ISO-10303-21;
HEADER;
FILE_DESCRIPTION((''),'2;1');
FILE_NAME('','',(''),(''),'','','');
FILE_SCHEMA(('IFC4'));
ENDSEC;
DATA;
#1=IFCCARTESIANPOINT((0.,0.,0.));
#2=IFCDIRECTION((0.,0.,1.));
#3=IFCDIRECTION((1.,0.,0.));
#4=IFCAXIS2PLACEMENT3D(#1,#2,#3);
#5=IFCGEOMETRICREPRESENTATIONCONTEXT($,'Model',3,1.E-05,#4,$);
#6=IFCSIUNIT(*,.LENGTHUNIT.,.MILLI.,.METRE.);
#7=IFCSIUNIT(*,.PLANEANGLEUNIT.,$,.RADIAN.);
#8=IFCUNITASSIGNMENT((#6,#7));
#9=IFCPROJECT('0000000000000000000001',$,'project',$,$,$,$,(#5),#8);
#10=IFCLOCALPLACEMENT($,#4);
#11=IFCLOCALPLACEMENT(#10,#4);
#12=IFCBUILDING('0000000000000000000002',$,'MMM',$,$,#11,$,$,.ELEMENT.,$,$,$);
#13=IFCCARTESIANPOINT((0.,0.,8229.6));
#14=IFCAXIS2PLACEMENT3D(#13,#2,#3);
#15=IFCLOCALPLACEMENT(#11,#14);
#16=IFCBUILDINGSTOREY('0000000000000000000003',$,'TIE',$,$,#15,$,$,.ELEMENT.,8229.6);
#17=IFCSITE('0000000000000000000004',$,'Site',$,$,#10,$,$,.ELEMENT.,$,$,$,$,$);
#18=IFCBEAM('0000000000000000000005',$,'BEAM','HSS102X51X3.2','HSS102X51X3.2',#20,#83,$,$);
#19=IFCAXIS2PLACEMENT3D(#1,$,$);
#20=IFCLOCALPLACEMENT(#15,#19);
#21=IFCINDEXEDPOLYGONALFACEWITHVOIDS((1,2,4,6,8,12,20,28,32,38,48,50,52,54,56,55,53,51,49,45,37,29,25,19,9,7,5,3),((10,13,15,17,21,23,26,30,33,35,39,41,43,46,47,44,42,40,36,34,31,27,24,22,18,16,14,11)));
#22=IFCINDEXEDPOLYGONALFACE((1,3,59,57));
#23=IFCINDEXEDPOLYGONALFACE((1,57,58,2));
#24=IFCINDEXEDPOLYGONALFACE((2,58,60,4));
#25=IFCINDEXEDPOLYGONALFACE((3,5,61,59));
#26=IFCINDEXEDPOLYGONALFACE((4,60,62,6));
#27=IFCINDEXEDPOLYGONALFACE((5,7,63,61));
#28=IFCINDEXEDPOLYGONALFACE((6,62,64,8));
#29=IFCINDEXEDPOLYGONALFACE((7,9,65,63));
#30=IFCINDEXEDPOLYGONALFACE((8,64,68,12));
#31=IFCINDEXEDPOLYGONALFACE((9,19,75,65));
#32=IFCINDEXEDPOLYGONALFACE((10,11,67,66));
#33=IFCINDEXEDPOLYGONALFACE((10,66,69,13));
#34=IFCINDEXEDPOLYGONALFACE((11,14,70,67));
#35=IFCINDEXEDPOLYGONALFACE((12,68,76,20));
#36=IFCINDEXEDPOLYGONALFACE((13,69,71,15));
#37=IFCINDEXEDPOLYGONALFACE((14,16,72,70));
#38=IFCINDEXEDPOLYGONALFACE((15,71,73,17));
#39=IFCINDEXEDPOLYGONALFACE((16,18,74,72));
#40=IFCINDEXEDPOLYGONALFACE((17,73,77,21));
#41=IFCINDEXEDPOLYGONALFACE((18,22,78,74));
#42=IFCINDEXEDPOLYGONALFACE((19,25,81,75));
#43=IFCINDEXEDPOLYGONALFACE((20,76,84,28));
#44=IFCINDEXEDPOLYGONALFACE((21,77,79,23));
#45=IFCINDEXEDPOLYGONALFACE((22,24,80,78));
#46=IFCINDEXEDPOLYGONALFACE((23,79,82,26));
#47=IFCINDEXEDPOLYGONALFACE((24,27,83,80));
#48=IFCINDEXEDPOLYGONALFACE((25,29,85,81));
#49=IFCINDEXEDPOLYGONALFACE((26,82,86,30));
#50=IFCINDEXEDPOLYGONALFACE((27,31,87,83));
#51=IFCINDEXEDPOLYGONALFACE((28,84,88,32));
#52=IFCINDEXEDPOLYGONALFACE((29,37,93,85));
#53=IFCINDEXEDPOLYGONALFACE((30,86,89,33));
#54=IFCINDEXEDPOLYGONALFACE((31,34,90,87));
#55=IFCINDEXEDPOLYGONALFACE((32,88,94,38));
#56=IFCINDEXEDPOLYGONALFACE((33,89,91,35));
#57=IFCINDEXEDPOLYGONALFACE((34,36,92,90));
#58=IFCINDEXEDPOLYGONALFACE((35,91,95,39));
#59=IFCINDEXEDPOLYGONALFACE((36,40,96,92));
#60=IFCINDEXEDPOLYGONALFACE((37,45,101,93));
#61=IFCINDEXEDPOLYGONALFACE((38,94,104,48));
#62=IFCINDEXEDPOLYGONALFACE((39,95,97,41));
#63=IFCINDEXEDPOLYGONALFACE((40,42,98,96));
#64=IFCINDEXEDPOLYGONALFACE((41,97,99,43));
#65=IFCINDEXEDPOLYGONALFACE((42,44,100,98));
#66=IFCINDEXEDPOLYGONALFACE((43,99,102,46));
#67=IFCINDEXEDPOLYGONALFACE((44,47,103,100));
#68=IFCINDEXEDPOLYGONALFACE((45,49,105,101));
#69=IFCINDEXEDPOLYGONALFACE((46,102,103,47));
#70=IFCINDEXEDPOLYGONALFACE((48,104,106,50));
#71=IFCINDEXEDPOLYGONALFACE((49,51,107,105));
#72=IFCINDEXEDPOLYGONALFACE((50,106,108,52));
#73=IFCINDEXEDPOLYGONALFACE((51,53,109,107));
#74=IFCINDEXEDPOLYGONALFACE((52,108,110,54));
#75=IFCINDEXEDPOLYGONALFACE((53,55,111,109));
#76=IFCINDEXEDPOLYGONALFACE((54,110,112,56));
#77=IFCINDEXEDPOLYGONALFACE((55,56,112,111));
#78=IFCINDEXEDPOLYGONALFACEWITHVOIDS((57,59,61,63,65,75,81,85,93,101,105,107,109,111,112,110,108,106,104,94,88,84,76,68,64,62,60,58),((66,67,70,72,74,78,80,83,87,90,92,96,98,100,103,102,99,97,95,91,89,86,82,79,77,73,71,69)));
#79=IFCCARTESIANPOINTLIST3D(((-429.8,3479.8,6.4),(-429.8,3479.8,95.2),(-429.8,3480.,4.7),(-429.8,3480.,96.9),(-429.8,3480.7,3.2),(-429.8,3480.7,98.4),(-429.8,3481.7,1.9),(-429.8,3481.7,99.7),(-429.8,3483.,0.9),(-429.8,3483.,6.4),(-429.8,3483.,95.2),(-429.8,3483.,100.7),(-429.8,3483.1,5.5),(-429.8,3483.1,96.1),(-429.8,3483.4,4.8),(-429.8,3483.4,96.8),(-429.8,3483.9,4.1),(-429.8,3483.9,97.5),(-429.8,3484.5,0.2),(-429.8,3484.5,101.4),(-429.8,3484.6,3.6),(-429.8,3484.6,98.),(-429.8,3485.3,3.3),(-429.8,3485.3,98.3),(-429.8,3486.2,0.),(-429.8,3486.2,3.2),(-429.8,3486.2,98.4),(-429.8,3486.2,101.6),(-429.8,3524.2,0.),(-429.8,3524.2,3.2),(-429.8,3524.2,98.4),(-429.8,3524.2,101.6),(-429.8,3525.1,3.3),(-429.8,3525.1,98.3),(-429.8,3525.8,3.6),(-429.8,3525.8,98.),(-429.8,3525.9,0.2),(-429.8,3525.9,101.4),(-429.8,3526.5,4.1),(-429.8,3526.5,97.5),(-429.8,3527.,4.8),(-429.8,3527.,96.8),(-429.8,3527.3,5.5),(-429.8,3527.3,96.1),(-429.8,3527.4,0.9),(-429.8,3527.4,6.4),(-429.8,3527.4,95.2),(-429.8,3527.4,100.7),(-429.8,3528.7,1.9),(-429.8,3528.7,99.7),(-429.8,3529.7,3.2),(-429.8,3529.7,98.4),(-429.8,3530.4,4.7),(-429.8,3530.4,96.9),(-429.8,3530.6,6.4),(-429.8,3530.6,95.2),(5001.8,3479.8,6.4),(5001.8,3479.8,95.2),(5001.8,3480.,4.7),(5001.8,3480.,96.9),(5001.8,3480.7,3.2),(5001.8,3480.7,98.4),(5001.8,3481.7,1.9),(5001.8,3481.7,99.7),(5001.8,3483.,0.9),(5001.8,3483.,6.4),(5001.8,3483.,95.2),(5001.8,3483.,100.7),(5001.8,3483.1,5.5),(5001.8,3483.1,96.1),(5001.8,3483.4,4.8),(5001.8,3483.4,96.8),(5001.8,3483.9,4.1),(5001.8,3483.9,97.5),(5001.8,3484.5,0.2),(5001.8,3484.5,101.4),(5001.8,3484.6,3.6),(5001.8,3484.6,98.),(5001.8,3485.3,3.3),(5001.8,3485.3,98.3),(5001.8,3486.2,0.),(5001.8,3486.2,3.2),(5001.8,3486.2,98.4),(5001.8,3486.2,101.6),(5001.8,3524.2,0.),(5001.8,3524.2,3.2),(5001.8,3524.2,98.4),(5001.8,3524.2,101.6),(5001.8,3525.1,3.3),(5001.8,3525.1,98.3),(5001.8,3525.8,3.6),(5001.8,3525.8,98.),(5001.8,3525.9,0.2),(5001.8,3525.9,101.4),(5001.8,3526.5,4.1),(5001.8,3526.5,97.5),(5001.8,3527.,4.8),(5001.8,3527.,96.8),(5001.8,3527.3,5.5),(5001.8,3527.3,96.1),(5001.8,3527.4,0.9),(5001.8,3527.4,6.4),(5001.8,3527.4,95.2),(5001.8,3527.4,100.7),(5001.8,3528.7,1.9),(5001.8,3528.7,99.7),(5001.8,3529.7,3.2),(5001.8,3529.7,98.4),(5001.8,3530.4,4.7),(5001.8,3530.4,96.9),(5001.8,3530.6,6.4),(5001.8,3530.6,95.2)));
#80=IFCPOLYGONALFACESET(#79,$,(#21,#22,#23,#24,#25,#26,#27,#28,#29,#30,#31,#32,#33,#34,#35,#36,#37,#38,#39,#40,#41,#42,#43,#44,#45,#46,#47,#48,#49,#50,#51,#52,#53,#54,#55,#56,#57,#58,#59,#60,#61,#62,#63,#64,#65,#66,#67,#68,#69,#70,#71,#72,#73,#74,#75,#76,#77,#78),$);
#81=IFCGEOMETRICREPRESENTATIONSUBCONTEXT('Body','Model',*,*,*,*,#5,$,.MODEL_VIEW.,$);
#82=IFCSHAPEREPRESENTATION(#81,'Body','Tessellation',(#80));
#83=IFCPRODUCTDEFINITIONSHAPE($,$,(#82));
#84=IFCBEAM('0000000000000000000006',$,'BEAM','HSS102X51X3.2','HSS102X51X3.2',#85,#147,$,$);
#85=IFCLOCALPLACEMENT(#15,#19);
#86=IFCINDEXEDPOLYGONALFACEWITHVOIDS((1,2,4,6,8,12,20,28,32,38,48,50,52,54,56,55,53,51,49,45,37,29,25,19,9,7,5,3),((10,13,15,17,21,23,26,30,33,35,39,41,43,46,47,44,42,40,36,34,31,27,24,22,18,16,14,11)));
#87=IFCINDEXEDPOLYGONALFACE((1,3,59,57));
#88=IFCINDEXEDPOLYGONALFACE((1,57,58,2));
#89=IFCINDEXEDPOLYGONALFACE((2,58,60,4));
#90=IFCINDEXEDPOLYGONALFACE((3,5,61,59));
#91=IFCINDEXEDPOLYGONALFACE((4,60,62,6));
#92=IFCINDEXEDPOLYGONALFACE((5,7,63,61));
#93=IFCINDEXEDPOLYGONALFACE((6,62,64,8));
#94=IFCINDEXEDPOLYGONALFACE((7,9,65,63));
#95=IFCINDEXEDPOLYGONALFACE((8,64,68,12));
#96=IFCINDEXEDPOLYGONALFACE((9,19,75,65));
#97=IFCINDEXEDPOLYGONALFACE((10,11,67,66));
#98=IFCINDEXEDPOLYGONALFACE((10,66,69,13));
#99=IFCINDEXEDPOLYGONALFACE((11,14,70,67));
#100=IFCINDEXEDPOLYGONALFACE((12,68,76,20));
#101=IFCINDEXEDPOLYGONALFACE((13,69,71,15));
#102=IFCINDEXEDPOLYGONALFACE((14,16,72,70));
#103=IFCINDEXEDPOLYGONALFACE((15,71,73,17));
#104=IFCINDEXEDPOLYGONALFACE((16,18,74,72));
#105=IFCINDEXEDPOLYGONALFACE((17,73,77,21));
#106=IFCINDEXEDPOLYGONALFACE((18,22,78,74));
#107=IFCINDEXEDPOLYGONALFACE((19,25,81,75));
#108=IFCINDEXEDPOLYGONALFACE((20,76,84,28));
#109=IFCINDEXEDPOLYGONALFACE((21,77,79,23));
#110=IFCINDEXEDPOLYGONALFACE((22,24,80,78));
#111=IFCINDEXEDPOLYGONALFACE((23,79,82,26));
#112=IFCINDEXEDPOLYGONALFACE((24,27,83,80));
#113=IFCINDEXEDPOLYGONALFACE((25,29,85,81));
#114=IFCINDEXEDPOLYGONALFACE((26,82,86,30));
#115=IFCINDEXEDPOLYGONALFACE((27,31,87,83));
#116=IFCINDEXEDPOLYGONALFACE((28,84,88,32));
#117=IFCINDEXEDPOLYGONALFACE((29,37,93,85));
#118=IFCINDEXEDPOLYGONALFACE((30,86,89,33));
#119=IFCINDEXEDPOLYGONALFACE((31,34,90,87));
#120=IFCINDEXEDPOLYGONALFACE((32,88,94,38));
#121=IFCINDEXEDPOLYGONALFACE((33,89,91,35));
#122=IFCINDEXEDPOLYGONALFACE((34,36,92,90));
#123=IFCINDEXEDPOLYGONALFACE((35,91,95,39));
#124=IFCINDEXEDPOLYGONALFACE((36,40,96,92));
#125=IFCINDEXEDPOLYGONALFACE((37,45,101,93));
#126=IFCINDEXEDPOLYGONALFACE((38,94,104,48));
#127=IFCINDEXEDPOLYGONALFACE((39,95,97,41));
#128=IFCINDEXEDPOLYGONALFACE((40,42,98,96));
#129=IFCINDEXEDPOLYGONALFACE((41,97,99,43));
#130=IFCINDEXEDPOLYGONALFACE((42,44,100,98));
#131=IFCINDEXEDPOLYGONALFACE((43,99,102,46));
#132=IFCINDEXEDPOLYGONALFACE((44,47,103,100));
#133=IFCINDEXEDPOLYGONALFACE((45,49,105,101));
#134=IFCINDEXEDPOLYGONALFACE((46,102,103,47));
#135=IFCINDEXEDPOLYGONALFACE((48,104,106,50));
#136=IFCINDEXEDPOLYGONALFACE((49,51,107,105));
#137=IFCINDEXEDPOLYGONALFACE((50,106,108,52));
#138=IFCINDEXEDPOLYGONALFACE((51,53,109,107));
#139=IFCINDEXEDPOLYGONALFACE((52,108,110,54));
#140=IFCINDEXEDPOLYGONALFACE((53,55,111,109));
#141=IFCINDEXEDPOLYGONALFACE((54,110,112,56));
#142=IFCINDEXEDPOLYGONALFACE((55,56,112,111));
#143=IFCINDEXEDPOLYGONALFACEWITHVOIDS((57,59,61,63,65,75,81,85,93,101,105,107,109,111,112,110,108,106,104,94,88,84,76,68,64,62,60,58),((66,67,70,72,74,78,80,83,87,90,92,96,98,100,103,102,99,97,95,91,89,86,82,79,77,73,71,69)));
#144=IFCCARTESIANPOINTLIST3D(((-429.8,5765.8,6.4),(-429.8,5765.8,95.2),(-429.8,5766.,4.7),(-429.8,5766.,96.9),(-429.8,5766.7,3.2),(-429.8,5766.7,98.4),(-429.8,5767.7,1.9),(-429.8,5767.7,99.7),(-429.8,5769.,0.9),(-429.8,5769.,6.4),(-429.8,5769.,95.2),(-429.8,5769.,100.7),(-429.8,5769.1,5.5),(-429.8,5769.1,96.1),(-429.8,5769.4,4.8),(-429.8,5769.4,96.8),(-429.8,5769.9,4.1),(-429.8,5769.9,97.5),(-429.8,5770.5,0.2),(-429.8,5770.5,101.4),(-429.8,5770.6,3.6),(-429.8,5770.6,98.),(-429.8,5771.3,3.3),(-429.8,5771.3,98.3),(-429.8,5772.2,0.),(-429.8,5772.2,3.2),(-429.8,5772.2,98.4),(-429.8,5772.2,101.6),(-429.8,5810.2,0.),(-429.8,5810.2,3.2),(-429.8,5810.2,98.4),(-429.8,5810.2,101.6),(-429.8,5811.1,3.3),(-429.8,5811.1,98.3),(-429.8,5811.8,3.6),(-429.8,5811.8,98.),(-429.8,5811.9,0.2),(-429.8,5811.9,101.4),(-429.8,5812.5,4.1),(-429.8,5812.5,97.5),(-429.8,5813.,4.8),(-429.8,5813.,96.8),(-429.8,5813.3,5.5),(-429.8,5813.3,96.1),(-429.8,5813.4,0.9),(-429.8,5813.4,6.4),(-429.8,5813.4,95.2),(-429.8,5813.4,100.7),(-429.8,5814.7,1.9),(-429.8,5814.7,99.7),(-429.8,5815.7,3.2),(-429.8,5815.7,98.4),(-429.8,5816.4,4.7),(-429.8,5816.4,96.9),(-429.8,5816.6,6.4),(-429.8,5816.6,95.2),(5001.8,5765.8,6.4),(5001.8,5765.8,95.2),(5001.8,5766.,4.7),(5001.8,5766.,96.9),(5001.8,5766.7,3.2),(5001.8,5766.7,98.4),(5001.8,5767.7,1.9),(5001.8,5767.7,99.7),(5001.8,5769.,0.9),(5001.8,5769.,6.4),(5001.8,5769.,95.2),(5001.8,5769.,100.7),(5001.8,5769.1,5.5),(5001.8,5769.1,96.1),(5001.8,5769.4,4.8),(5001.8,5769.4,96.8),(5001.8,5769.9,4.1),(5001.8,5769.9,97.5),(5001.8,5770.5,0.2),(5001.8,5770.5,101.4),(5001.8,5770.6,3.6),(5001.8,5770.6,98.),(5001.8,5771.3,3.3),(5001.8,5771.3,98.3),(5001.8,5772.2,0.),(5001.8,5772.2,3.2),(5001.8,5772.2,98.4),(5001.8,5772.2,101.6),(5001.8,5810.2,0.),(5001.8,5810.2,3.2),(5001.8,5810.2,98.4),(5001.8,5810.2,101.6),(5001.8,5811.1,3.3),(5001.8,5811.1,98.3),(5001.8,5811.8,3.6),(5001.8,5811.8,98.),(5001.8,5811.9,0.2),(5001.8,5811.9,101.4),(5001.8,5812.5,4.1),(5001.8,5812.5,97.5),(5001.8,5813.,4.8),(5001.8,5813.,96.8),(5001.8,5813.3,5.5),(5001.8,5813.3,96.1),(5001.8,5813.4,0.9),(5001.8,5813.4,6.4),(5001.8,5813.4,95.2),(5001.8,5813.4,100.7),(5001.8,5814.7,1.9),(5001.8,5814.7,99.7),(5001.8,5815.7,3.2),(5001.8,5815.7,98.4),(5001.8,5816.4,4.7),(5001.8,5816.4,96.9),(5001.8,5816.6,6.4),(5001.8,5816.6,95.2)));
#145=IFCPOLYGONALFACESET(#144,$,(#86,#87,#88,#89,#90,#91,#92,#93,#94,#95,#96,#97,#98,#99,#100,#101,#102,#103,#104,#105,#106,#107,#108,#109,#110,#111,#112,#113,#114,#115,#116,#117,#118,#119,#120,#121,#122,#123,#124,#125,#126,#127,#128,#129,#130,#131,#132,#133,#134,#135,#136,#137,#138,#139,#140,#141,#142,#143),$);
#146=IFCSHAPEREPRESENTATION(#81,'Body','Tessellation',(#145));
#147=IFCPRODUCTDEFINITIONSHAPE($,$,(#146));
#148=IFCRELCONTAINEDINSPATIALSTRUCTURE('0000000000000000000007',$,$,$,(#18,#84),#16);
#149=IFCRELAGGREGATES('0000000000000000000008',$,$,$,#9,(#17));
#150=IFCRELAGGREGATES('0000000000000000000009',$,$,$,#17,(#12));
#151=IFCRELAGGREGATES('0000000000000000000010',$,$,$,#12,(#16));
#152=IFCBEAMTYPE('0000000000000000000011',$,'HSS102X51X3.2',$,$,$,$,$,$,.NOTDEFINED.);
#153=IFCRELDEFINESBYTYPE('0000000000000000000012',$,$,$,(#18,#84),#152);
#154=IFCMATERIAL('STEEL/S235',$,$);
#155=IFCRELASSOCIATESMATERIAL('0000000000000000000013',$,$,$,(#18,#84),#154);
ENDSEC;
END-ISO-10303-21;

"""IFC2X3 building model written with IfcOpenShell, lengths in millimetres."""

from ifc_helpers import new_model, si_unit, frame, origin_with_axes, origin_2d_with_axis, place, context, subcontext, project, spatial, hollow_rectangle, extrude, material, type_object, element, save


model = new_model("IFC2X3")

# Units and contexts
model_context = context("Model", 3, precision=1e-05, world=origin_with_axes())
body_context = subcontext(model_context, "Body", "Model", "MODEL_VIEW")
ifc_project = project(units=[si_unit("LENGTHUNIT", "METRE", prefix="MILLI"), si_unit("PLANEANGLEUNIT", "RADIAN")], contexts=[model_context])

# Site, building, storey
site_placement = place(None, origin_with_axes())
site = spatial("IfcSite", under=ifc_project, at=site_placement, Name="Site", CompositionType="ELEMENT")
building_placement = place(site_placement, origin_with_axes())
building = spatial("IfcBuilding", under=site, at=building_placement, Name="MMM", CompositionType="ELEMENT")
storey_placement = place(building_placement, frame((0.0, 0.0, 8229.6), z_axis=(0.0, 0.0, 1.0), x_axis=(1.0, 0.0, 0.0)))
storey = spatial("IfcBuildingStorey", under=building, at=storey_placement, Name="TIE", CompositionType="ELEMENT", Elevation=8229.6)

# Shared definitions
ifc_material = material(Name="STEEL/S235")

# Beams
beam_type_1 = type_object("IfcBeamType", Name="HSS102X51X3.2", PredefinedType="NOTDEFINED")
for number, where, z_axis, x_axis, name in (
    (1, (-429.8, 3505.2, 50.8), (0.0, 0.0, 1.0), (1.0, 0.0, 0.0), "BEAM"),
    (2, (-429.8, 5791.2, 50.8), (0.0, 0.0, 1.0), (1.0, 0.0, 0.0), "BEAM"),
):
    element("IfcBeam", number, at=place(storey_placement, frame(where, z_axis=z_axis, x_axis=x_axis)), inside=storey, type_object=beam_type_1, material=ifc_material, Name=name, Description="HSS102X51X3.2", ObjectType="HSS102X51X3.2", context=body_context, shape_type="SweptSolid", body=[
        extrude(hollow_rectangle(XDim=50.8, YDim=101.6, WallThickness=3.2, InnerFilletRadius=3.2, OuterFilletRadius=6.4, at=origin_2d_with_axis()), frame((5431.6, 0.0, 0.0), z_axis=(-1.0, 0.0, 0.0), x_axis=(0.0, -1.0, 0.0)), (0.0, 0.0, 1.0), 5431.6),
    ])

save(model, "model.ifc")
